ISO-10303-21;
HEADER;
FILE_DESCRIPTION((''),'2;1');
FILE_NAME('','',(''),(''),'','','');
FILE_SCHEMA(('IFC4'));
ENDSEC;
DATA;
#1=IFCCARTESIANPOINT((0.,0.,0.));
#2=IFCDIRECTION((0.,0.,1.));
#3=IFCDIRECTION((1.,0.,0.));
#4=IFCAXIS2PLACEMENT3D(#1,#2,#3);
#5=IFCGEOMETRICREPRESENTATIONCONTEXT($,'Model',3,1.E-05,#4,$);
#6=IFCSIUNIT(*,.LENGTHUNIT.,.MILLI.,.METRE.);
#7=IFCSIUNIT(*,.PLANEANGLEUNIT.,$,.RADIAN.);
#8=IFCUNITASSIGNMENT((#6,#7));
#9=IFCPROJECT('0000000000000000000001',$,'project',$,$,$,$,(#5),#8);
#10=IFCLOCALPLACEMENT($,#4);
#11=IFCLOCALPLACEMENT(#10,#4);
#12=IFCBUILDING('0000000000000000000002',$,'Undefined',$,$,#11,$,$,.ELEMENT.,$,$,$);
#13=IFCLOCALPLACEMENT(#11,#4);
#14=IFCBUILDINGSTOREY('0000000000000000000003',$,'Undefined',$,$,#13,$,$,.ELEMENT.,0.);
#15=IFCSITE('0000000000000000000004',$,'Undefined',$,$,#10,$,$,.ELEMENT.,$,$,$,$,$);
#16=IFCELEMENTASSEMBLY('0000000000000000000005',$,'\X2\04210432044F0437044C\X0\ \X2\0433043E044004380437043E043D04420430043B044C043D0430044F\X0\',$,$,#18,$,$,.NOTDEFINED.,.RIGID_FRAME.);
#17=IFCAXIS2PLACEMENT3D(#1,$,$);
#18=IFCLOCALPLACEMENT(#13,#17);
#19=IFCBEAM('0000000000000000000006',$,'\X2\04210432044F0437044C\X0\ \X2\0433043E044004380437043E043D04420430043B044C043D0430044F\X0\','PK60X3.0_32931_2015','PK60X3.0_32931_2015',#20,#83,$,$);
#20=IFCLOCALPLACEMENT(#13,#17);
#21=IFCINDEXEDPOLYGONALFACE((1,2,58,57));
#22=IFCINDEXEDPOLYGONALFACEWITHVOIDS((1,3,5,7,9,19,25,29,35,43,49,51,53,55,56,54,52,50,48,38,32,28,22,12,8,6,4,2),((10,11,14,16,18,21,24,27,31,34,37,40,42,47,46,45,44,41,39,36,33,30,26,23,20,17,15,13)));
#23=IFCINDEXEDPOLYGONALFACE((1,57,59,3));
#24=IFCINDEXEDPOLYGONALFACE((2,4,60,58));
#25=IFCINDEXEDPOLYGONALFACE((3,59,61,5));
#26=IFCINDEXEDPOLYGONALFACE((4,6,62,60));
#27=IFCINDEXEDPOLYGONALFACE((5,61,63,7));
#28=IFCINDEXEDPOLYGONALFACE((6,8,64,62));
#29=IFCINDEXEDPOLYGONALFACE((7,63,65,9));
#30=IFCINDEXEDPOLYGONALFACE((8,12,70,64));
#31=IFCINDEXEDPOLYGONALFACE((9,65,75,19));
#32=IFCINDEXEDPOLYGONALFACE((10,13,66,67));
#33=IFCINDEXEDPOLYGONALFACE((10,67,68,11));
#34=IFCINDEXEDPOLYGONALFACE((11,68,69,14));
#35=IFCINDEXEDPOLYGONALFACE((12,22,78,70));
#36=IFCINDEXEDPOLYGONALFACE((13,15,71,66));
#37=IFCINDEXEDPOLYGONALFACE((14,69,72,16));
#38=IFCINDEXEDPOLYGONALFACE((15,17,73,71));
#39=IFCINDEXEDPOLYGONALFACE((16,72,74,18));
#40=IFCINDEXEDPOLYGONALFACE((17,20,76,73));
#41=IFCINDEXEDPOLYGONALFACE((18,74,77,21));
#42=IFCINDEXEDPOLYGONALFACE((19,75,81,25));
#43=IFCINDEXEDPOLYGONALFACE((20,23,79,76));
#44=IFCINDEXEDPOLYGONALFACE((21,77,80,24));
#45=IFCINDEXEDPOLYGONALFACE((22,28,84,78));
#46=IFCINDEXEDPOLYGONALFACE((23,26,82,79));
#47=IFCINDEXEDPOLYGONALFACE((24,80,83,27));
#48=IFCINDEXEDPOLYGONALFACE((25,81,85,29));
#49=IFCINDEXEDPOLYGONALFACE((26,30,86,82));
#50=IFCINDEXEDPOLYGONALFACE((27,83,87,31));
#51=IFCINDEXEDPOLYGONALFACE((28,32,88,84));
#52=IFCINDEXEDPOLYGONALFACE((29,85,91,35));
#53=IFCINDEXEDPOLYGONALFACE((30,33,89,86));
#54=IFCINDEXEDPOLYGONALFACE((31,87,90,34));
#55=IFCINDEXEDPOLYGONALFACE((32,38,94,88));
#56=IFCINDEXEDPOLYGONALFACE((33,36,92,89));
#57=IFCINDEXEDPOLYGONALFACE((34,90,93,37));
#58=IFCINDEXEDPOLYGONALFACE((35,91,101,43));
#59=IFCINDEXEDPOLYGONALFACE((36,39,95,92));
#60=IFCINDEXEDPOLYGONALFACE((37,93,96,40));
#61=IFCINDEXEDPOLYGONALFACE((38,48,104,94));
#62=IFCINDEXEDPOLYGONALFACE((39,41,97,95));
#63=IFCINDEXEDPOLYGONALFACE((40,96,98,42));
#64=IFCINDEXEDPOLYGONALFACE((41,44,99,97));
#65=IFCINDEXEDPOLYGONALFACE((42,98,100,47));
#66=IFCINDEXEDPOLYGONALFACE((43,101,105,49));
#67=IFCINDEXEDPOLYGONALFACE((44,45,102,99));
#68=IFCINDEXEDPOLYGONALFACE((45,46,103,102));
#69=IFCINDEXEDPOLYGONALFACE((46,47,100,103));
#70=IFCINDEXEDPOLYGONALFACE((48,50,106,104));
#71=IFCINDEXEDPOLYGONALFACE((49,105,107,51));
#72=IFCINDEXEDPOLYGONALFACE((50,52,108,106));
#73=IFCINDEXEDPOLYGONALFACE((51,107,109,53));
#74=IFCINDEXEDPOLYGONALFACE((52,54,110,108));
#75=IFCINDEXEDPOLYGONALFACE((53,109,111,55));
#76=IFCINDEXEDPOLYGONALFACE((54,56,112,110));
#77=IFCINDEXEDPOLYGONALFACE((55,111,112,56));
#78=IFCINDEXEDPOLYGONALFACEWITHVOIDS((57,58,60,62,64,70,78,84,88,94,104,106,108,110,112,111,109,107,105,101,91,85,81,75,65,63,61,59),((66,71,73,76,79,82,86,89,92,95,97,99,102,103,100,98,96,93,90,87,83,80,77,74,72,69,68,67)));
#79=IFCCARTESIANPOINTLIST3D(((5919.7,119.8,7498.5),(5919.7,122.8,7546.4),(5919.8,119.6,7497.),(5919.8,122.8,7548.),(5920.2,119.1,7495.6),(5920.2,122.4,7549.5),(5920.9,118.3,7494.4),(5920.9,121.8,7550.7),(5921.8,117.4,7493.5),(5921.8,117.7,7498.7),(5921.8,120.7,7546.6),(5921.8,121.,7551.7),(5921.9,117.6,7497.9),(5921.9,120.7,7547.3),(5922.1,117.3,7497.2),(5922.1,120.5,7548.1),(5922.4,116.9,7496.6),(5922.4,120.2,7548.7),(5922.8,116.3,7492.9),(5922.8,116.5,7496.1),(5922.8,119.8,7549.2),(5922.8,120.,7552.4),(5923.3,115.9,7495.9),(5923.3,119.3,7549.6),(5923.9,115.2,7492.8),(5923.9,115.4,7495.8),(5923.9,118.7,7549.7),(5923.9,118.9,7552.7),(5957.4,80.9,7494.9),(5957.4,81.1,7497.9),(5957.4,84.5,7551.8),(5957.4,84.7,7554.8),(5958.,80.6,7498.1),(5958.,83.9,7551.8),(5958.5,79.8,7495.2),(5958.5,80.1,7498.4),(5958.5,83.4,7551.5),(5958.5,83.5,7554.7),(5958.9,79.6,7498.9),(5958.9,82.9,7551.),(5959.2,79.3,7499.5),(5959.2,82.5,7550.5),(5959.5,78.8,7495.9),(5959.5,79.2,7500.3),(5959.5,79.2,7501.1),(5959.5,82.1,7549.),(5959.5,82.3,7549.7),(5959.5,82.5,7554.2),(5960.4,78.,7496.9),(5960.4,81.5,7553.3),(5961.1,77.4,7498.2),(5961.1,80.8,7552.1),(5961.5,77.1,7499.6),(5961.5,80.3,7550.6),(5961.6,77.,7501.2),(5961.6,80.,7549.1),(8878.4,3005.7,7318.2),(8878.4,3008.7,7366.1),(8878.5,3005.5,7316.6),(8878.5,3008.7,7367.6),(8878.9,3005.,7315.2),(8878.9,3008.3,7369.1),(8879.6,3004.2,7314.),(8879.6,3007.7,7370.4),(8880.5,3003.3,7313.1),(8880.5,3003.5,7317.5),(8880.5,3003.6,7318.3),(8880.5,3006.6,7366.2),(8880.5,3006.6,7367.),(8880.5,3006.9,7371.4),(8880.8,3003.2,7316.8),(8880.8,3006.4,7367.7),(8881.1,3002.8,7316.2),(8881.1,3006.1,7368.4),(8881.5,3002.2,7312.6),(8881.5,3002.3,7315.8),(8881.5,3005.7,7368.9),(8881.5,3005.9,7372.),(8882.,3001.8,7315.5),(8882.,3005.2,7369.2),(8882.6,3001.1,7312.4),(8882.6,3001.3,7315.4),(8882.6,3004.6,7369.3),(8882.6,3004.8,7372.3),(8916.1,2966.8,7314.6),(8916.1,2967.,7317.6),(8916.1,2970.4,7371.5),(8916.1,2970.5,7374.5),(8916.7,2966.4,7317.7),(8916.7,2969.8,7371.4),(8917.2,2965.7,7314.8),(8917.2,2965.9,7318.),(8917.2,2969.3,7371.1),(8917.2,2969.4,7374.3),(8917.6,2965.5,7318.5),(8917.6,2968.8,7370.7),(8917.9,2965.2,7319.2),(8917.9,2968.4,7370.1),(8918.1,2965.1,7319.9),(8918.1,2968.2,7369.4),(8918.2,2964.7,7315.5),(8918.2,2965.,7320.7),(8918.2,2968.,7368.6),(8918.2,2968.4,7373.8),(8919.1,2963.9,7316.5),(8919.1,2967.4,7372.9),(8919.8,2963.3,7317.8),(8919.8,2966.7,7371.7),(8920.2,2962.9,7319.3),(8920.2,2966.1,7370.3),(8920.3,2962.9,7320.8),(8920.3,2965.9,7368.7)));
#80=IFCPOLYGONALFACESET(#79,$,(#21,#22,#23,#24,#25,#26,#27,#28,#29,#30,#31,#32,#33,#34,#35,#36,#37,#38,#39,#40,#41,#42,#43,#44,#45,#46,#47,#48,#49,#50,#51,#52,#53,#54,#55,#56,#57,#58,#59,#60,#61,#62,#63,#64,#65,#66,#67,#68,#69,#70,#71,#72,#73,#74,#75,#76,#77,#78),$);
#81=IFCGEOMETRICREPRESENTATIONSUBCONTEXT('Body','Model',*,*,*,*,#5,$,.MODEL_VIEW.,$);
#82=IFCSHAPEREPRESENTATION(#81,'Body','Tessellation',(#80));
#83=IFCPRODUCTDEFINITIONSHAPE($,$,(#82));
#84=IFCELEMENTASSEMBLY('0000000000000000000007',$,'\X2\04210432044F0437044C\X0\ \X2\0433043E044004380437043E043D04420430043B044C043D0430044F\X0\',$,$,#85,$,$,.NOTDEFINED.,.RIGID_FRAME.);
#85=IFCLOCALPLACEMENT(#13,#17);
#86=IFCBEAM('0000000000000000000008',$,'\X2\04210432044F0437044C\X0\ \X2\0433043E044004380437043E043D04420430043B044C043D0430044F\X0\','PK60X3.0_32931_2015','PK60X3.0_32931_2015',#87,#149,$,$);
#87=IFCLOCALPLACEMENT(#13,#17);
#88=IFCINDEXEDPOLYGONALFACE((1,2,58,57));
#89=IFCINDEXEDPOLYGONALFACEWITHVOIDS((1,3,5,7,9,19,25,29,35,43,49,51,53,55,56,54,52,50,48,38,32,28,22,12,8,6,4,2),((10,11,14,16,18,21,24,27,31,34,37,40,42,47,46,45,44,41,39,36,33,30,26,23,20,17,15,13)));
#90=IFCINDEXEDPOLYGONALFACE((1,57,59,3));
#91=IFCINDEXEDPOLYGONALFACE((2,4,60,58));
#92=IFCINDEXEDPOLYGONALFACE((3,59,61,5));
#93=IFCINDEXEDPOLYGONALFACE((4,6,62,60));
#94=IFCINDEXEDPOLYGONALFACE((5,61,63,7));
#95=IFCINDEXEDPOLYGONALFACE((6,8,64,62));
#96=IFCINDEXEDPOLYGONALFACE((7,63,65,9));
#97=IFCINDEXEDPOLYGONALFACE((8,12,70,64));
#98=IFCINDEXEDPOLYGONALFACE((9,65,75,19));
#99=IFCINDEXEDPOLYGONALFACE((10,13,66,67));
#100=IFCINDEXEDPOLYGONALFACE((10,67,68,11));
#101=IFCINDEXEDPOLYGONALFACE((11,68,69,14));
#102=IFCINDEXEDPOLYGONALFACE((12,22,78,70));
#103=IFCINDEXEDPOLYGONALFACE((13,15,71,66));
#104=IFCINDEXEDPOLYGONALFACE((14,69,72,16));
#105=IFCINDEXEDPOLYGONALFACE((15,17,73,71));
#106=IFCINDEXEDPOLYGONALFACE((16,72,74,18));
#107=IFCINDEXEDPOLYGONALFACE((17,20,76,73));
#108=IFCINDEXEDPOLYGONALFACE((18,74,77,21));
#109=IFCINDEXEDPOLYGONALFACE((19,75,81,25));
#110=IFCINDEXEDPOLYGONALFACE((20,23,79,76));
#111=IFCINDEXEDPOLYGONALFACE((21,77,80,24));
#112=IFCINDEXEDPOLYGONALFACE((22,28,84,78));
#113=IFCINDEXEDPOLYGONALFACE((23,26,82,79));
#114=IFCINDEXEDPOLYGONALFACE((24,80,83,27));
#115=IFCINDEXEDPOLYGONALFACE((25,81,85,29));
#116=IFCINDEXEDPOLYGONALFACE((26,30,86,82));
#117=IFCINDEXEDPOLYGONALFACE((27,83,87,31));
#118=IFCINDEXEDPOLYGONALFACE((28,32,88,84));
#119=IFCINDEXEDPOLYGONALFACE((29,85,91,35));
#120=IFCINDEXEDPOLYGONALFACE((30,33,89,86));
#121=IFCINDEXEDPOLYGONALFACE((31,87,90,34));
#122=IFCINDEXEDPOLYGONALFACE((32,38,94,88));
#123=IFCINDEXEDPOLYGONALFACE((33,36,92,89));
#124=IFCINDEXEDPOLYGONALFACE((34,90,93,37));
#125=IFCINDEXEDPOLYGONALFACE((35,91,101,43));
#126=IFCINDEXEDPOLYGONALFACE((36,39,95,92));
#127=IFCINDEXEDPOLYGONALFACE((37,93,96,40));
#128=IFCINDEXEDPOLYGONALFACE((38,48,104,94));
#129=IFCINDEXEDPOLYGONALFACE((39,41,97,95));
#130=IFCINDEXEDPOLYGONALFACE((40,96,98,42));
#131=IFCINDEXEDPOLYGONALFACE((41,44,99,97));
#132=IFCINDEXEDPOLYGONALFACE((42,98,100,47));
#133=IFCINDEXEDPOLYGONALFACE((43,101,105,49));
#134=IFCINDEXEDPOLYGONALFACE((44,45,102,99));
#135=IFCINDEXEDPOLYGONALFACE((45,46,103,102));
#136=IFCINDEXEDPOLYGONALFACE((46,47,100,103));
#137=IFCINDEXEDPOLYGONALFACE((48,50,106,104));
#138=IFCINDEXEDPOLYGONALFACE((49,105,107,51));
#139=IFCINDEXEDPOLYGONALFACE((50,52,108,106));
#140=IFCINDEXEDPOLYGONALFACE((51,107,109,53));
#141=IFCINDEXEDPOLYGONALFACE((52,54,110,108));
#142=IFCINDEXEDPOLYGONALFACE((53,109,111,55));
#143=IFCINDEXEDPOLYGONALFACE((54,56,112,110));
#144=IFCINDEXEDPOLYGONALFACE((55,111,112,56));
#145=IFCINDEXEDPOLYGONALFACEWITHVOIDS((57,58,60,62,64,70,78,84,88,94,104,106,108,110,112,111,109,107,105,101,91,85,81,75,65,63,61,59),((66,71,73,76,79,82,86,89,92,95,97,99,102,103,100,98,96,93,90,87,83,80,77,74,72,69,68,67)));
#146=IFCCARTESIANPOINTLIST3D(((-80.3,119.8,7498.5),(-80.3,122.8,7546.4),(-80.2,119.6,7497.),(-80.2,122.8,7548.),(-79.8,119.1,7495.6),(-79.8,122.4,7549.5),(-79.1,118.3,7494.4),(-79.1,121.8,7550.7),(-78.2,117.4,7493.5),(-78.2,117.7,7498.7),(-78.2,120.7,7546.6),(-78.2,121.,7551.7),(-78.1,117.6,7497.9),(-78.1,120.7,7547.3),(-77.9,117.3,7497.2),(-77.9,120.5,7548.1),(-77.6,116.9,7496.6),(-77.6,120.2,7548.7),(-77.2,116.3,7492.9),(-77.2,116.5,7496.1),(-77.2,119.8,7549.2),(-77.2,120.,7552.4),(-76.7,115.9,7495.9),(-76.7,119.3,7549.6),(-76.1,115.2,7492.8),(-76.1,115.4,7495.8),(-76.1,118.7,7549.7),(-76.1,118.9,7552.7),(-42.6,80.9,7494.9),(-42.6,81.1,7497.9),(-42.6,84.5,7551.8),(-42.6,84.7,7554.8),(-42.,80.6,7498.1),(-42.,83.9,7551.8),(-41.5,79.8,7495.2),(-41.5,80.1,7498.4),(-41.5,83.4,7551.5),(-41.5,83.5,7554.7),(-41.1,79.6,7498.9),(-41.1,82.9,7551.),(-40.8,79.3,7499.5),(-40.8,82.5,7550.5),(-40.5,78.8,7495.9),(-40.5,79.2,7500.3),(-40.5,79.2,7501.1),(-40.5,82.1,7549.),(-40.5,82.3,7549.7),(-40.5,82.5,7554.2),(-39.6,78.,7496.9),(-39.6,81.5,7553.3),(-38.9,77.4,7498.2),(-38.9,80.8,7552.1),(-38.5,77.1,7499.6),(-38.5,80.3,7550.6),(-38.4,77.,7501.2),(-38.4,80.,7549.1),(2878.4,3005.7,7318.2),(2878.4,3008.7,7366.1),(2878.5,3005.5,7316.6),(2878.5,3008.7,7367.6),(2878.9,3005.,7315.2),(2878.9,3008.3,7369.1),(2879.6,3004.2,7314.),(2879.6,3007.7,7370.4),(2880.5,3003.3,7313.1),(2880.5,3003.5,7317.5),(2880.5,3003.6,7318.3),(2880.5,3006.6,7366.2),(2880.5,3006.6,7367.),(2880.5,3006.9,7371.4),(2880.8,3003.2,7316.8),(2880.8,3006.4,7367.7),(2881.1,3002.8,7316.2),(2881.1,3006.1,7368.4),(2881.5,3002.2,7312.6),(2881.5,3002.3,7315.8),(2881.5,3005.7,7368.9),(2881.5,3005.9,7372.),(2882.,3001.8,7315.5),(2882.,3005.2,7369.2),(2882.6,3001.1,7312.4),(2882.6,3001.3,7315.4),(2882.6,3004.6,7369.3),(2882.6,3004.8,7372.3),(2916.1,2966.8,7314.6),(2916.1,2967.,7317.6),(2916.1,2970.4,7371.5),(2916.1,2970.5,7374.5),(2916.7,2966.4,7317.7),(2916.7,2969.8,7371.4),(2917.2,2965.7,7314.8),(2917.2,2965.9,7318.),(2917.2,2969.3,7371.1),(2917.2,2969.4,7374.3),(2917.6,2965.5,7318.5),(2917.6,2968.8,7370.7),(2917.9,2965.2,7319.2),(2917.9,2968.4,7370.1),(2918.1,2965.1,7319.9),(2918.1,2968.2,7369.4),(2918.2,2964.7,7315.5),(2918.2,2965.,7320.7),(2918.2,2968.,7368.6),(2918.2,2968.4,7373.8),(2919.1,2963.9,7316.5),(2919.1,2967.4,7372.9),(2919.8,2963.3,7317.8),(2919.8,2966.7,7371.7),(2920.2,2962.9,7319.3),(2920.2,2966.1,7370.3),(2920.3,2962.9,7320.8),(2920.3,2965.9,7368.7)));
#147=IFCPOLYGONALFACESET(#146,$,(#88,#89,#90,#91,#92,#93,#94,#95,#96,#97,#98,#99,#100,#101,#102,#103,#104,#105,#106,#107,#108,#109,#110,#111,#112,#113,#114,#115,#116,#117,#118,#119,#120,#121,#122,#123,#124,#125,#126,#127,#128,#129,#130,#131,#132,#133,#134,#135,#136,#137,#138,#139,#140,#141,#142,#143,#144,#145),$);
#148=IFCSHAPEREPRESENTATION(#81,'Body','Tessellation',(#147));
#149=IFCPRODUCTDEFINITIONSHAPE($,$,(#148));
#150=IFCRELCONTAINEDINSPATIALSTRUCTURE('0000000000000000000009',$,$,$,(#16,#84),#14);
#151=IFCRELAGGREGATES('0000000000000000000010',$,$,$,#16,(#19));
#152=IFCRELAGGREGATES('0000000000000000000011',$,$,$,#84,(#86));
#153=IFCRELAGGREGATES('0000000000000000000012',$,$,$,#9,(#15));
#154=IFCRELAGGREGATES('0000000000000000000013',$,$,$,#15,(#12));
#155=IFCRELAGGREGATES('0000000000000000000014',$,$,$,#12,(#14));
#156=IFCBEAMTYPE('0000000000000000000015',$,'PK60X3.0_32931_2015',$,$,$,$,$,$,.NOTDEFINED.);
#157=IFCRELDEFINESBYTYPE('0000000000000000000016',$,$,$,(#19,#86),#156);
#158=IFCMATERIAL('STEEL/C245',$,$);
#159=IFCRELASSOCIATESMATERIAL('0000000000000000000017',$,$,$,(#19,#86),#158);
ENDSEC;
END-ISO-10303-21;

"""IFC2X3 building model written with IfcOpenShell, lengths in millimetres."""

from ifc_helpers import new_model, si_unit, frame, origin_with_axes, origin_2d_with_axis, place, context, subcontext, project, spatial, hollow_rectangle, extrude, material, type_object, element, aggregate, save


model = new_model("IFC2X3")

# Units and contexts
model_context = context("Model", 3, precision=1e-05, world=origin_with_axes())
body_context = subcontext(model_context, "Body", "Model", "MODEL_VIEW")
ifc_project = project(units=[si_unit("LENGTHUNIT", "METRE", prefix="MILLI"), si_unit("PLANEANGLEUNIT", "RADIAN")], contexts=[model_context])

# Site, building, storey
site_placement = place(None, origin_with_axes())
site = spatial("IfcSite", under=ifc_project, at=site_placement, Name="Undefined", CompositionType="ELEMENT")
building_placement = place(site_placement, origin_with_axes())
building = spatial("IfcBuilding", under=site, at=building_placement, Name="Undefined", CompositionType="ELEMENT")
storey_placement = place(building_placement, origin_with_axes())
storey = spatial("IfcBuildingStorey", under=building, at=storey_placement, Name="Undefined", CompositionType="ELEMENT", Elevation=0.0)

# Shared definitions
ifc_material = material(Name="STEEL/C245")

# Element assemblies, beams
assembly_1_placement = place(storey_placement, origin_with_axes())
assembly_1 = element("IfcElementAssembly", 1, at=assembly_1_placement, inside=storey, Name="Связь горизонтальная", AssemblyPlace="NOTDEFINED", PredefinedType="RIGID_FRAME")
beam_type_1 = type_object("IfcBeamType", Name="PK60X3.0_32931_2015", PredefinedType="NOTDEFINED")
beam_1_placement = place(assembly_1_placement, frame((5940.7, 99.9, 7523.8), z_axis=(0.0, 0.062378, 0.998053), x_axis=(0.715179, 0.69758, -0.043599)))
beam_1 = element("IfcBeam", 2, at=beam_1_placement, type_object=beam_type_1, material=ifc_material, Name="Связь горизонтальная", Description="PK60X3.0_32931_2015", ObjectType="PK60X3.0_32931_2015", context=body_context, shape_type="SweptSolid", body=[
    extrude(hollow_rectangle(XDim=60.0, YDim=60.0, WallThickness=3.0, InnerFilletRadius=3.0, OuterFilletRadius=6.0, at=origin_2d_with_axis()), frame((4137.0, 0.0, 0.0), z_axis=(-1.0, 0.0, 0.0), x_axis=(0.0, -1.0, 0.0)), (0.0, 0.0, 1.0), 4137.0),
])
aggregate(assembly_1, [beam_1])
assembly_2_placement = place(storey_placement, origin_with_axes())
assembly_2 = element("IfcElementAssembly", 3, at=assembly_2_placement, inside=storey, Name="Связь горизонтальная", AssemblyPlace="NOTDEFINED", PredefinedType="RIGID_FRAME")
beam_2_placement = place(assembly_2_placement, frame((-59.3, 99.9, 7523.8), z_axis=(0.0, 0.062378, 0.998053), x_axis=(0.715179, 0.69758, -0.043599)))
beam_2 = element("IfcBeam", 4, at=beam_2_placement, type_object=beam_type_1, material=ifc_material, Name="Связь горизонтальная", Description="PK60X3.0_32931_2015", ObjectType="PK60X3.0_32931_2015", context=body_context, shape_type="SweptSolid", body=[
    extrude(hollow_rectangle(XDim=60.0, YDim=60.0, WallThickness=3.0, InnerFilletRadius=3.0, OuterFilletRadius=6.0, at=origin_2d_with_axis()), frame((4137.0, 0.0, 0.0), z_axis=(-1.0, 0.0, 0.0), x_axis=(0.0, -1.0, 0.0)), (0.0, 0.0, 1.0), 4137.0),
])
aggregate(assembly_2, [beam_2])

save(model, "model.ifc")
